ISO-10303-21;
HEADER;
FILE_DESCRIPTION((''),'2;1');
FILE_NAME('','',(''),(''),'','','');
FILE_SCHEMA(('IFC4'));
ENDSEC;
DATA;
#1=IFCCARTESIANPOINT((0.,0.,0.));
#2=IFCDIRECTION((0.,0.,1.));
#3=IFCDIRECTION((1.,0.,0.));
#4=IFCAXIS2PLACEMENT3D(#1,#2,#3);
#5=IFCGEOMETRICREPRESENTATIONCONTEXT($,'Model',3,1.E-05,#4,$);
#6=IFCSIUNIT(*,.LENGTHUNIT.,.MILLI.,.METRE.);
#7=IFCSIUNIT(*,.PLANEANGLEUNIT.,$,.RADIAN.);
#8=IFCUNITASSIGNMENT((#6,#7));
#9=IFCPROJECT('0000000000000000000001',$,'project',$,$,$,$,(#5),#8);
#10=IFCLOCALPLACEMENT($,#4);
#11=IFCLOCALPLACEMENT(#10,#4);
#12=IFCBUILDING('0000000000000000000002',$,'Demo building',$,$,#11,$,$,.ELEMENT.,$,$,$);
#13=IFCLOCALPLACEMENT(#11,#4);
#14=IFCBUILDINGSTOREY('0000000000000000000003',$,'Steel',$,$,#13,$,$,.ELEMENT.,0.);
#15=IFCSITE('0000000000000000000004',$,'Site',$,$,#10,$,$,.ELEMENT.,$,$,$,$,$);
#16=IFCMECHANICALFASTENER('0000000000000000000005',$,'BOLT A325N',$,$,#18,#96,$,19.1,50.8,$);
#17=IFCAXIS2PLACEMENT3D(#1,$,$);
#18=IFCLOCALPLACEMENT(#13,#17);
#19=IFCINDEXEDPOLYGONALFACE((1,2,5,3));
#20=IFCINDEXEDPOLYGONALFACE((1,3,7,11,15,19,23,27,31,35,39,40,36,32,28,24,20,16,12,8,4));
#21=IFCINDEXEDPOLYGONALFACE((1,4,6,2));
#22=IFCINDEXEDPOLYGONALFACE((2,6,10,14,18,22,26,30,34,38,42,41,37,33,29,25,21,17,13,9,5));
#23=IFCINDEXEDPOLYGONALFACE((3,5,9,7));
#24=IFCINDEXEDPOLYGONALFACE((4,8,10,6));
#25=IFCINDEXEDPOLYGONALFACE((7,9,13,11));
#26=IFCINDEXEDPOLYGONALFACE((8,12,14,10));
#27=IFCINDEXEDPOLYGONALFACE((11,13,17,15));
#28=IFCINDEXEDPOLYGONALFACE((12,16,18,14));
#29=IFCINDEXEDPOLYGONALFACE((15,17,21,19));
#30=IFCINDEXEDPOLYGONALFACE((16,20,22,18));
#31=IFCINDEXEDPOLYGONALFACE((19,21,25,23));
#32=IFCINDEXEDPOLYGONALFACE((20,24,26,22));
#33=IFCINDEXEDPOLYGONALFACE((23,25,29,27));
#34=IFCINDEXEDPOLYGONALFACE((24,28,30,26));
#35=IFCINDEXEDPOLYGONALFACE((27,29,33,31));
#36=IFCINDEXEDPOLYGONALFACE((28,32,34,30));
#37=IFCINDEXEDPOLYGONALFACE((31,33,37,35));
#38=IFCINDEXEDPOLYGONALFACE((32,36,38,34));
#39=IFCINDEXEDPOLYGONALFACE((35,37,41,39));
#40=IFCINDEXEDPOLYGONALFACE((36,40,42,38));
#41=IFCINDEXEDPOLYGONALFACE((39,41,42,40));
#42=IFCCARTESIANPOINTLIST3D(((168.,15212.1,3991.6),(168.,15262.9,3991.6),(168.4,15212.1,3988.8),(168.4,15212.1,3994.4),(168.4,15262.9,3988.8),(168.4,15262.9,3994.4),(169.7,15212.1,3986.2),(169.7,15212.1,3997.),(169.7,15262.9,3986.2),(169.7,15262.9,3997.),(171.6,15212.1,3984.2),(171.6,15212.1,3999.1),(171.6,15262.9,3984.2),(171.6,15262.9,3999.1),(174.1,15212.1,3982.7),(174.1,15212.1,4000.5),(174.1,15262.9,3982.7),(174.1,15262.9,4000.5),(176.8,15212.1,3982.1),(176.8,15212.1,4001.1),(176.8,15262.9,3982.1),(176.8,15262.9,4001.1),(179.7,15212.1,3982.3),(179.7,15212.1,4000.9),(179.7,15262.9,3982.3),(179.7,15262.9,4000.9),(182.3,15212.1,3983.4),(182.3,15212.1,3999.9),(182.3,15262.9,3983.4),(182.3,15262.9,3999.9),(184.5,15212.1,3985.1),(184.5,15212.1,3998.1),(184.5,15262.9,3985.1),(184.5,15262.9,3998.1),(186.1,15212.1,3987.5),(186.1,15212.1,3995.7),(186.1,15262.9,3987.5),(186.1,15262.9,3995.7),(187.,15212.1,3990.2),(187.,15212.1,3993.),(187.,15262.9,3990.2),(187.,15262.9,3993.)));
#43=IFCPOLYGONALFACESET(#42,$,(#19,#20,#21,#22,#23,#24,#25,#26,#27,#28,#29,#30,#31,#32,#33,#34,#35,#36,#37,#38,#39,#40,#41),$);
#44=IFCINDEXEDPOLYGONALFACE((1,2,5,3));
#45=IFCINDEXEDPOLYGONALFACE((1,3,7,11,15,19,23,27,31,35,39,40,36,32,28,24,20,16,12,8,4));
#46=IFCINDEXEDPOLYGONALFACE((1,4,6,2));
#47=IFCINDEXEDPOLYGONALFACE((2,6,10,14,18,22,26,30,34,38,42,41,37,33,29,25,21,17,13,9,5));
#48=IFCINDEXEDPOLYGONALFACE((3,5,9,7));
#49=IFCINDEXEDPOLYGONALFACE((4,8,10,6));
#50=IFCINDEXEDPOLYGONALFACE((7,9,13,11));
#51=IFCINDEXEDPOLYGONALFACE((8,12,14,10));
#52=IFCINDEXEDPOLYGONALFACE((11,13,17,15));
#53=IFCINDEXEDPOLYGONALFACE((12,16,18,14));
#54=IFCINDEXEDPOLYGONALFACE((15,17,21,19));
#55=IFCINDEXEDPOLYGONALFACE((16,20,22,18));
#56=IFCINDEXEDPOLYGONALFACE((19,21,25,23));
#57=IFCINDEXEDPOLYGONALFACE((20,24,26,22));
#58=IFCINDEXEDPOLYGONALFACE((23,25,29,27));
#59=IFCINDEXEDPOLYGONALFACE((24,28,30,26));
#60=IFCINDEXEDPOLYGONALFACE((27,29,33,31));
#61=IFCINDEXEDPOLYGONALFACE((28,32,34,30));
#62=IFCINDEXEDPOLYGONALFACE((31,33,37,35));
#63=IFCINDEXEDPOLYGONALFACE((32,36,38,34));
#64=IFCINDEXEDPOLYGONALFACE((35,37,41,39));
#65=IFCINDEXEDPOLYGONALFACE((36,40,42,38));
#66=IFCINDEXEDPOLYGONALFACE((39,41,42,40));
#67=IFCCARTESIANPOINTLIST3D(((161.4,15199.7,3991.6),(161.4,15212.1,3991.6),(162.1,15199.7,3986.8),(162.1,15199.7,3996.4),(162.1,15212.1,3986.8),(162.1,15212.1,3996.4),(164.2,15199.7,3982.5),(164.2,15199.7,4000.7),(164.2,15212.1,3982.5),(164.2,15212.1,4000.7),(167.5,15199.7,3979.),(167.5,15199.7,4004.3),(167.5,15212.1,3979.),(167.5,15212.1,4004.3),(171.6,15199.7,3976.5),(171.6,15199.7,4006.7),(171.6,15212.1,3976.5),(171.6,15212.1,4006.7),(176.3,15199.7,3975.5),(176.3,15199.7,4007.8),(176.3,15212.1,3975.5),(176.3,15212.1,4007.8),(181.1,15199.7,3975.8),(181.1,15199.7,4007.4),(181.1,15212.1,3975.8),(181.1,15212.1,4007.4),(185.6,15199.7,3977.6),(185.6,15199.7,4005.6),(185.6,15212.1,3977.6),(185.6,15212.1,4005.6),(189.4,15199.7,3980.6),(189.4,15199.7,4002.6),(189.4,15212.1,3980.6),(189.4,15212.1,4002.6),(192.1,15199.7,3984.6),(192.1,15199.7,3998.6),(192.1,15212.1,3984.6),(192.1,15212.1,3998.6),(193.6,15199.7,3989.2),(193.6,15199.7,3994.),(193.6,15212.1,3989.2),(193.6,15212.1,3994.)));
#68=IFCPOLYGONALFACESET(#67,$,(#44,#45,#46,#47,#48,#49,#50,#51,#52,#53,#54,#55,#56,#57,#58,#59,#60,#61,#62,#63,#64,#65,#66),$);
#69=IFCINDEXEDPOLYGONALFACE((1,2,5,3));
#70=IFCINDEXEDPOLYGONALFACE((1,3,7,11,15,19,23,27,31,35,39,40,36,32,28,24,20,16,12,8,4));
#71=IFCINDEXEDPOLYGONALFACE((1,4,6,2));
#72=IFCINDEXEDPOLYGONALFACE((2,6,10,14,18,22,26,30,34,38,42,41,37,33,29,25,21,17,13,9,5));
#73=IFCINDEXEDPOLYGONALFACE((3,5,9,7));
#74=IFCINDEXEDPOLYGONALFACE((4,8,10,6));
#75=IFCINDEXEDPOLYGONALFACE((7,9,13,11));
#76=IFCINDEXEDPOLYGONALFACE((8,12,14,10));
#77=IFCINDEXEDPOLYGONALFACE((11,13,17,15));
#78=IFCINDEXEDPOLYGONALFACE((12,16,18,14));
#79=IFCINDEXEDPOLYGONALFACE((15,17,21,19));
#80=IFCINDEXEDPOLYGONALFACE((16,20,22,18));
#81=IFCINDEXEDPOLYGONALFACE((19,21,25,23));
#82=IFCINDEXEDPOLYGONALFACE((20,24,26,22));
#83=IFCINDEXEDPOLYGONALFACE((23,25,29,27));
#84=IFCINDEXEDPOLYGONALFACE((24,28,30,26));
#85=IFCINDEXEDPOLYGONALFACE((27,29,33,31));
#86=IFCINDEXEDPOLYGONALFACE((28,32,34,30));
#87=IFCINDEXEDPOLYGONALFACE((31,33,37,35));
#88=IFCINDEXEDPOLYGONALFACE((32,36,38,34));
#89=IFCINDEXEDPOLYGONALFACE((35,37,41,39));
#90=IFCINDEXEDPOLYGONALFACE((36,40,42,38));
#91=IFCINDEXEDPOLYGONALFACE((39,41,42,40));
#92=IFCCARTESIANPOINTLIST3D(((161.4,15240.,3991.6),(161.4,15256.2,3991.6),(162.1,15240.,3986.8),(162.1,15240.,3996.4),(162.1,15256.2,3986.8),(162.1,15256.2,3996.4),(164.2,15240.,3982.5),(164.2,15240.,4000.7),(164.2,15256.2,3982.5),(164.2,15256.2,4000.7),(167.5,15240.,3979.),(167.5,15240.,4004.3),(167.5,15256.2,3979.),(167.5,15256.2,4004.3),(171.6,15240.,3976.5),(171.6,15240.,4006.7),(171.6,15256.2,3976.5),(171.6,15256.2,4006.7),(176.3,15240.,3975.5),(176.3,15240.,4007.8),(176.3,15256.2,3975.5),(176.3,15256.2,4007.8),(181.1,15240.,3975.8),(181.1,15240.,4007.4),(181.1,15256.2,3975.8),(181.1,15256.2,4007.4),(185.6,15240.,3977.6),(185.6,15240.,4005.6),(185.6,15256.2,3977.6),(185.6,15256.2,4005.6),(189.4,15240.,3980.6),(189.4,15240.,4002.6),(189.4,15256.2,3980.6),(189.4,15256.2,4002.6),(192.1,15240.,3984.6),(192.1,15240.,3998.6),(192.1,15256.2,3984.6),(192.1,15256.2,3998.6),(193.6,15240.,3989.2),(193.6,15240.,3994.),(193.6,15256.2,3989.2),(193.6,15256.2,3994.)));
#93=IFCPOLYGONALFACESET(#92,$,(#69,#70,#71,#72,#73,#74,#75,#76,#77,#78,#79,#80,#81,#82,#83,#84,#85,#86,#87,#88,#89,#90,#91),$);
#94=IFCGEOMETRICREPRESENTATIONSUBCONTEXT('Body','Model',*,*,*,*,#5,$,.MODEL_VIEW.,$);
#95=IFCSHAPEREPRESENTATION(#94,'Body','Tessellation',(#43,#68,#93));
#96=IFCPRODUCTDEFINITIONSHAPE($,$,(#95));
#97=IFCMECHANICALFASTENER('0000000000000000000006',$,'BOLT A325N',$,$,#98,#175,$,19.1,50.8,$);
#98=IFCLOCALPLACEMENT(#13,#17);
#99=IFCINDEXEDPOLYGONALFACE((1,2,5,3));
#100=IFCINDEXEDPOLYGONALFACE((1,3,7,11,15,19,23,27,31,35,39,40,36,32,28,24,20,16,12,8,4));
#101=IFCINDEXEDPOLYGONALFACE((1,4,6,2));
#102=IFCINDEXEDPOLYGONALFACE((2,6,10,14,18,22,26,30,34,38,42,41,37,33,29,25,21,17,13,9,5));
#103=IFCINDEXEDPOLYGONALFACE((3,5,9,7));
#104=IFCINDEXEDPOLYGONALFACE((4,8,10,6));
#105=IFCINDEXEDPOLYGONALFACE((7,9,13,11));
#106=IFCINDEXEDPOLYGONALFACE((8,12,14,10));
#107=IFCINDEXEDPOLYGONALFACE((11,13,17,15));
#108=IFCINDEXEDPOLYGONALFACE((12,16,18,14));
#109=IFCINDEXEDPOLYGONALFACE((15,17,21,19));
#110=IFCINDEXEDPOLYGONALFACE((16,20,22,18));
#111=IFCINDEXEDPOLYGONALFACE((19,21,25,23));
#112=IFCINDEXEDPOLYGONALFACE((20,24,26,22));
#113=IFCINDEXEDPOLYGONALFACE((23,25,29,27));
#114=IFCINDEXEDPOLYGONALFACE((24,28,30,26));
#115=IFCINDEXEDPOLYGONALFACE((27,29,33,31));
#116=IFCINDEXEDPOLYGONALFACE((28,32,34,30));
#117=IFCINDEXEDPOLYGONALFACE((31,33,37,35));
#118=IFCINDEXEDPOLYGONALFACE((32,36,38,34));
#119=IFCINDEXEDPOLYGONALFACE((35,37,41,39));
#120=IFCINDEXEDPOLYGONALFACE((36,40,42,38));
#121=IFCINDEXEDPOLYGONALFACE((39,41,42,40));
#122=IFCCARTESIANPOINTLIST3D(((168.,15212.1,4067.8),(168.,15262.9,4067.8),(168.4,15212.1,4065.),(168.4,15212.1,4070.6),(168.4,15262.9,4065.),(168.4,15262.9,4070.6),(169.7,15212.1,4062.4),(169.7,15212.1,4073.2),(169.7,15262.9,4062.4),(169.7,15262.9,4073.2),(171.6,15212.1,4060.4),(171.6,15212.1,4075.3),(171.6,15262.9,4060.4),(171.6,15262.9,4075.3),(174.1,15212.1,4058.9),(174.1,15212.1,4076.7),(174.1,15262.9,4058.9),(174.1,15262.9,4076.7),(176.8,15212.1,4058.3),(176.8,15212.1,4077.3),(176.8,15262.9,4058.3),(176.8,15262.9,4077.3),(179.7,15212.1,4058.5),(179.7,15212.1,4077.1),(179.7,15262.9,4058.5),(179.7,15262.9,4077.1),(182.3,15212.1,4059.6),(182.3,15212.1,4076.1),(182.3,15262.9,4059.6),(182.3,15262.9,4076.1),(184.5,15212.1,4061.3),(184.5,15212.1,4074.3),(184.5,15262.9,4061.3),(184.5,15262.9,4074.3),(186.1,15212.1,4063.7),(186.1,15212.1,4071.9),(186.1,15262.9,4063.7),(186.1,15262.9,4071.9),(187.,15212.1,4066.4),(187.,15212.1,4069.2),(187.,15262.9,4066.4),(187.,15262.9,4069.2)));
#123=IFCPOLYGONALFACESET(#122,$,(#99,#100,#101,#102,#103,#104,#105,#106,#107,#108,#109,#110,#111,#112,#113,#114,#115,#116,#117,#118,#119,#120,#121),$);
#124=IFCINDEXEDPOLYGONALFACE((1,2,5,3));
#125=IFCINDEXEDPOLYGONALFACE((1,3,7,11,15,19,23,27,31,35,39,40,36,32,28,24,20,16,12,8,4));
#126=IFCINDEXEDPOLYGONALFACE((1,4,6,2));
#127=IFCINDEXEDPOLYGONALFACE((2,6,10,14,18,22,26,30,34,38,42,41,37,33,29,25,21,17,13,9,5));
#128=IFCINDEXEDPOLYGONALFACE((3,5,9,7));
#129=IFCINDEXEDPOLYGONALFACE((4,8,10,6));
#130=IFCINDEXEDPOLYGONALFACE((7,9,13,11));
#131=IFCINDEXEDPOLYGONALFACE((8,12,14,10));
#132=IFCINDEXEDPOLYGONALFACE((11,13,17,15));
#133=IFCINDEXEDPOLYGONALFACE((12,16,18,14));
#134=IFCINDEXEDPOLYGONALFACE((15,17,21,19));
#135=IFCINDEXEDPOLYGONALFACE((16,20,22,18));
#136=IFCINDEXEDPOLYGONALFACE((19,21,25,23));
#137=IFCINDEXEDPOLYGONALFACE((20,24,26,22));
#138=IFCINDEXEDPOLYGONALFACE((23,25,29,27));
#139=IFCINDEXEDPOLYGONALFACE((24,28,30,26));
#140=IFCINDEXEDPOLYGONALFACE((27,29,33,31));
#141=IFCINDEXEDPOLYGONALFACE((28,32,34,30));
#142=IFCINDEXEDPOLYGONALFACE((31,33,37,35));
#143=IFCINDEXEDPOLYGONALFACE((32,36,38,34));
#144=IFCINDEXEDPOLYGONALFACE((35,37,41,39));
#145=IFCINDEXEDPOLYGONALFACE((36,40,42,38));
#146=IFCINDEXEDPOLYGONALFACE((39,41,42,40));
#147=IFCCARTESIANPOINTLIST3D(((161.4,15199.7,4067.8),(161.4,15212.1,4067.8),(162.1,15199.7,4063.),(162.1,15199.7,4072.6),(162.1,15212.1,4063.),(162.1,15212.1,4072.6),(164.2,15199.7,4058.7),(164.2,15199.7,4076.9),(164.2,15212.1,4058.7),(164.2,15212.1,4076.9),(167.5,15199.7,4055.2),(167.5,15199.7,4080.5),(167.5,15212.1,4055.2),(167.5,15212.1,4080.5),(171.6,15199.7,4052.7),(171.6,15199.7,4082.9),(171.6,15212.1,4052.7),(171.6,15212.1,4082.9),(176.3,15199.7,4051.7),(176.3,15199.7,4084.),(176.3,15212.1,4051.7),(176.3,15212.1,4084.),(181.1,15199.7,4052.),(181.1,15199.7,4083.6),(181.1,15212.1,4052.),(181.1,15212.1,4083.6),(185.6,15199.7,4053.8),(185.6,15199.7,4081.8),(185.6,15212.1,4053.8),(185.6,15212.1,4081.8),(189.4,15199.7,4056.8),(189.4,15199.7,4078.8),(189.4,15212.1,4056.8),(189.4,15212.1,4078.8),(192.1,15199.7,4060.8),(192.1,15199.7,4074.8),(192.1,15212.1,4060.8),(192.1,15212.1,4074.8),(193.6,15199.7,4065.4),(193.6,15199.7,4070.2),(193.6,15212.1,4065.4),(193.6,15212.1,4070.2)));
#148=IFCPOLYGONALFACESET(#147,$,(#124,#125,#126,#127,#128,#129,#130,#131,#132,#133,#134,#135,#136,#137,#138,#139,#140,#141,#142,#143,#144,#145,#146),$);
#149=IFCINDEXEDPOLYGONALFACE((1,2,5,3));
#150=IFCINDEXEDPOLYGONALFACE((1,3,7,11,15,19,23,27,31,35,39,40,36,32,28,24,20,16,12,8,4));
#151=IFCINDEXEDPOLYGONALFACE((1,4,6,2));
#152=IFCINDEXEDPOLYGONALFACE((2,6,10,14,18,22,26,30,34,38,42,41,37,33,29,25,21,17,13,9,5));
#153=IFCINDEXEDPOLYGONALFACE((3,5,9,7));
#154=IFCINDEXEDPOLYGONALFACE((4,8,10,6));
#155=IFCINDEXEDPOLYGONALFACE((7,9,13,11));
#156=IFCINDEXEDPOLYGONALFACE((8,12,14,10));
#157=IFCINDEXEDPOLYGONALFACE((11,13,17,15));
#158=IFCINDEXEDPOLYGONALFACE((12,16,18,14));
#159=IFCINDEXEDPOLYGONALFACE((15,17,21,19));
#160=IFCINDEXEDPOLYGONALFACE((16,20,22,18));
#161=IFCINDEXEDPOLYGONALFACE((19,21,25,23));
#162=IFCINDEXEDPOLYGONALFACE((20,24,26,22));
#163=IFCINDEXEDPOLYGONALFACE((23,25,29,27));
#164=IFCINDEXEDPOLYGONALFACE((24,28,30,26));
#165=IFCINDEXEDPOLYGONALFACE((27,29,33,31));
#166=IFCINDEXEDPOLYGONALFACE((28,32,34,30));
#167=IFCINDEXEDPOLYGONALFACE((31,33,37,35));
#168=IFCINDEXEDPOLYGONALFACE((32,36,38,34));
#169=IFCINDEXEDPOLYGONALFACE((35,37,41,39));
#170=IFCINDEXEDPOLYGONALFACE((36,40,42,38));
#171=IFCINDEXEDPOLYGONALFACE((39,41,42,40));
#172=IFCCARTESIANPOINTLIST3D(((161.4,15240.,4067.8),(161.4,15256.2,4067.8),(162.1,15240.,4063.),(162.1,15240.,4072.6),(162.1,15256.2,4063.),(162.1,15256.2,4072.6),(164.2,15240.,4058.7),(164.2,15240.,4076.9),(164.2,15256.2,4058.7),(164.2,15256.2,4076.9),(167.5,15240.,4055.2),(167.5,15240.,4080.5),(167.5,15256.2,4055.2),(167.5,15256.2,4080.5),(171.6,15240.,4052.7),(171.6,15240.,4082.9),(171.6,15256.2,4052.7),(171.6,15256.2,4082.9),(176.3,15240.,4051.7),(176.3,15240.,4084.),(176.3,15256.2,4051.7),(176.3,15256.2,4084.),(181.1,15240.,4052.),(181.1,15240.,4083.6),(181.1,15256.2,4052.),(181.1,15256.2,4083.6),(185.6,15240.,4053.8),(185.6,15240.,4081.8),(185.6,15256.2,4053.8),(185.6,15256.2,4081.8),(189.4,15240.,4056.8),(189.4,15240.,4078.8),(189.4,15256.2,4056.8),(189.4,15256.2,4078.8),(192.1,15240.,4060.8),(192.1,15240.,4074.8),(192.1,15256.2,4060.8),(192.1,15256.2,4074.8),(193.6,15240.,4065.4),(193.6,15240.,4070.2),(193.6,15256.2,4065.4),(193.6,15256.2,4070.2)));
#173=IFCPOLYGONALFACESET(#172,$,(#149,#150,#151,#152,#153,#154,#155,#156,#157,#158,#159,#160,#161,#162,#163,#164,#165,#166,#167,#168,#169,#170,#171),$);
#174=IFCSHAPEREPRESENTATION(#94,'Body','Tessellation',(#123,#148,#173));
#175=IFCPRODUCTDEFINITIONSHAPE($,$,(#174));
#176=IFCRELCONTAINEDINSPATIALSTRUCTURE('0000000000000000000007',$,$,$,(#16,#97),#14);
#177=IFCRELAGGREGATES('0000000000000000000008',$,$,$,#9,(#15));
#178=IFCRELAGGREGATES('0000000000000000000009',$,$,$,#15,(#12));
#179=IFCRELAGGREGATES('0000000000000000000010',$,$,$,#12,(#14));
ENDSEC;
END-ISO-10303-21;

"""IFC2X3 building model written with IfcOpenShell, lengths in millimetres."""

from ifc_helpers import new_model, si_unit, frame, origin, origin_with_axes, origin_2d, place, context, subcontext, project, spatial, circle, extrude, element, save


model = new_model("IFC2X3")

# Units and contexts
model_context = context("Model", 3, precision=1e-05, world=origin_with_axes())
body_context = subcontext(model_context, "Body", "Model", "MODEL_VIEW")
ifc_project = project(units=[si_unit("LENGTHUNIT", "METRE", prefix="MILLI"), si_unit("PLANEANGLEUNIT", "RADIAN")], contexts=[model_context])

# Site, building, storey
site_placement = place(None, origin_with_axes())
site = spatial("IfcSite", under=ifc_project, at=site_placement, Name="Site", CompositionType="ELEMENT")
building_placement = place(site_placement, origin_with_axes())
building = spatial("IfcBuilding", under=site, at=building_placement, Name="Demo building", CompositionType="ELEMENT")
placement = place(building_placement, origin_with_axes())
storey = spatial("IfcBuildingStorey", under=building, at=placement, Name="Steel", CompositionType="ELEMENT", Elevation=0.0)

# Mechanical fasteners
for number, where, z_axis, x_axis, name in (
    (1, (177.5, 15212.1, 3991.6), (0.0, 1.0, 0.0), (-1.0, 0.0, 0.0), "BOLT A325N"),
    (2, (177.5, 15212.1, 4067.8), (0.0, 1.0, 0.0), (-1.0, 0.0, 0.0), "BOLT A325N"),
):
    element("IfcMechanicalFastener", number, at=place(placement, frame(where, z_axis=z_axis, x_axis=x_axis)), inside=storey, Name=name, NominalDiameter=19.1, NominalLength=50.8, context=body_context, shape_type="SweptSolid", body=[
        extrude(circle(Radius=9.5, at=origin_2d()), origin(), (0.0, 0.0, 1.0), 50.8),
        extrude(circle(Radius=16.2, at=origin_2d()), frame((0.0, 0.0, -12.4)), (0.0, 0.0, 1.0), 12.4),
        extrude(circle(Radius=16.2, at=origin_2d()), frame((0.0, 0.0, 27.9)), (0.0, 0.0, 1.0), 16.2),
    ])

save(model, "model.ifc")
